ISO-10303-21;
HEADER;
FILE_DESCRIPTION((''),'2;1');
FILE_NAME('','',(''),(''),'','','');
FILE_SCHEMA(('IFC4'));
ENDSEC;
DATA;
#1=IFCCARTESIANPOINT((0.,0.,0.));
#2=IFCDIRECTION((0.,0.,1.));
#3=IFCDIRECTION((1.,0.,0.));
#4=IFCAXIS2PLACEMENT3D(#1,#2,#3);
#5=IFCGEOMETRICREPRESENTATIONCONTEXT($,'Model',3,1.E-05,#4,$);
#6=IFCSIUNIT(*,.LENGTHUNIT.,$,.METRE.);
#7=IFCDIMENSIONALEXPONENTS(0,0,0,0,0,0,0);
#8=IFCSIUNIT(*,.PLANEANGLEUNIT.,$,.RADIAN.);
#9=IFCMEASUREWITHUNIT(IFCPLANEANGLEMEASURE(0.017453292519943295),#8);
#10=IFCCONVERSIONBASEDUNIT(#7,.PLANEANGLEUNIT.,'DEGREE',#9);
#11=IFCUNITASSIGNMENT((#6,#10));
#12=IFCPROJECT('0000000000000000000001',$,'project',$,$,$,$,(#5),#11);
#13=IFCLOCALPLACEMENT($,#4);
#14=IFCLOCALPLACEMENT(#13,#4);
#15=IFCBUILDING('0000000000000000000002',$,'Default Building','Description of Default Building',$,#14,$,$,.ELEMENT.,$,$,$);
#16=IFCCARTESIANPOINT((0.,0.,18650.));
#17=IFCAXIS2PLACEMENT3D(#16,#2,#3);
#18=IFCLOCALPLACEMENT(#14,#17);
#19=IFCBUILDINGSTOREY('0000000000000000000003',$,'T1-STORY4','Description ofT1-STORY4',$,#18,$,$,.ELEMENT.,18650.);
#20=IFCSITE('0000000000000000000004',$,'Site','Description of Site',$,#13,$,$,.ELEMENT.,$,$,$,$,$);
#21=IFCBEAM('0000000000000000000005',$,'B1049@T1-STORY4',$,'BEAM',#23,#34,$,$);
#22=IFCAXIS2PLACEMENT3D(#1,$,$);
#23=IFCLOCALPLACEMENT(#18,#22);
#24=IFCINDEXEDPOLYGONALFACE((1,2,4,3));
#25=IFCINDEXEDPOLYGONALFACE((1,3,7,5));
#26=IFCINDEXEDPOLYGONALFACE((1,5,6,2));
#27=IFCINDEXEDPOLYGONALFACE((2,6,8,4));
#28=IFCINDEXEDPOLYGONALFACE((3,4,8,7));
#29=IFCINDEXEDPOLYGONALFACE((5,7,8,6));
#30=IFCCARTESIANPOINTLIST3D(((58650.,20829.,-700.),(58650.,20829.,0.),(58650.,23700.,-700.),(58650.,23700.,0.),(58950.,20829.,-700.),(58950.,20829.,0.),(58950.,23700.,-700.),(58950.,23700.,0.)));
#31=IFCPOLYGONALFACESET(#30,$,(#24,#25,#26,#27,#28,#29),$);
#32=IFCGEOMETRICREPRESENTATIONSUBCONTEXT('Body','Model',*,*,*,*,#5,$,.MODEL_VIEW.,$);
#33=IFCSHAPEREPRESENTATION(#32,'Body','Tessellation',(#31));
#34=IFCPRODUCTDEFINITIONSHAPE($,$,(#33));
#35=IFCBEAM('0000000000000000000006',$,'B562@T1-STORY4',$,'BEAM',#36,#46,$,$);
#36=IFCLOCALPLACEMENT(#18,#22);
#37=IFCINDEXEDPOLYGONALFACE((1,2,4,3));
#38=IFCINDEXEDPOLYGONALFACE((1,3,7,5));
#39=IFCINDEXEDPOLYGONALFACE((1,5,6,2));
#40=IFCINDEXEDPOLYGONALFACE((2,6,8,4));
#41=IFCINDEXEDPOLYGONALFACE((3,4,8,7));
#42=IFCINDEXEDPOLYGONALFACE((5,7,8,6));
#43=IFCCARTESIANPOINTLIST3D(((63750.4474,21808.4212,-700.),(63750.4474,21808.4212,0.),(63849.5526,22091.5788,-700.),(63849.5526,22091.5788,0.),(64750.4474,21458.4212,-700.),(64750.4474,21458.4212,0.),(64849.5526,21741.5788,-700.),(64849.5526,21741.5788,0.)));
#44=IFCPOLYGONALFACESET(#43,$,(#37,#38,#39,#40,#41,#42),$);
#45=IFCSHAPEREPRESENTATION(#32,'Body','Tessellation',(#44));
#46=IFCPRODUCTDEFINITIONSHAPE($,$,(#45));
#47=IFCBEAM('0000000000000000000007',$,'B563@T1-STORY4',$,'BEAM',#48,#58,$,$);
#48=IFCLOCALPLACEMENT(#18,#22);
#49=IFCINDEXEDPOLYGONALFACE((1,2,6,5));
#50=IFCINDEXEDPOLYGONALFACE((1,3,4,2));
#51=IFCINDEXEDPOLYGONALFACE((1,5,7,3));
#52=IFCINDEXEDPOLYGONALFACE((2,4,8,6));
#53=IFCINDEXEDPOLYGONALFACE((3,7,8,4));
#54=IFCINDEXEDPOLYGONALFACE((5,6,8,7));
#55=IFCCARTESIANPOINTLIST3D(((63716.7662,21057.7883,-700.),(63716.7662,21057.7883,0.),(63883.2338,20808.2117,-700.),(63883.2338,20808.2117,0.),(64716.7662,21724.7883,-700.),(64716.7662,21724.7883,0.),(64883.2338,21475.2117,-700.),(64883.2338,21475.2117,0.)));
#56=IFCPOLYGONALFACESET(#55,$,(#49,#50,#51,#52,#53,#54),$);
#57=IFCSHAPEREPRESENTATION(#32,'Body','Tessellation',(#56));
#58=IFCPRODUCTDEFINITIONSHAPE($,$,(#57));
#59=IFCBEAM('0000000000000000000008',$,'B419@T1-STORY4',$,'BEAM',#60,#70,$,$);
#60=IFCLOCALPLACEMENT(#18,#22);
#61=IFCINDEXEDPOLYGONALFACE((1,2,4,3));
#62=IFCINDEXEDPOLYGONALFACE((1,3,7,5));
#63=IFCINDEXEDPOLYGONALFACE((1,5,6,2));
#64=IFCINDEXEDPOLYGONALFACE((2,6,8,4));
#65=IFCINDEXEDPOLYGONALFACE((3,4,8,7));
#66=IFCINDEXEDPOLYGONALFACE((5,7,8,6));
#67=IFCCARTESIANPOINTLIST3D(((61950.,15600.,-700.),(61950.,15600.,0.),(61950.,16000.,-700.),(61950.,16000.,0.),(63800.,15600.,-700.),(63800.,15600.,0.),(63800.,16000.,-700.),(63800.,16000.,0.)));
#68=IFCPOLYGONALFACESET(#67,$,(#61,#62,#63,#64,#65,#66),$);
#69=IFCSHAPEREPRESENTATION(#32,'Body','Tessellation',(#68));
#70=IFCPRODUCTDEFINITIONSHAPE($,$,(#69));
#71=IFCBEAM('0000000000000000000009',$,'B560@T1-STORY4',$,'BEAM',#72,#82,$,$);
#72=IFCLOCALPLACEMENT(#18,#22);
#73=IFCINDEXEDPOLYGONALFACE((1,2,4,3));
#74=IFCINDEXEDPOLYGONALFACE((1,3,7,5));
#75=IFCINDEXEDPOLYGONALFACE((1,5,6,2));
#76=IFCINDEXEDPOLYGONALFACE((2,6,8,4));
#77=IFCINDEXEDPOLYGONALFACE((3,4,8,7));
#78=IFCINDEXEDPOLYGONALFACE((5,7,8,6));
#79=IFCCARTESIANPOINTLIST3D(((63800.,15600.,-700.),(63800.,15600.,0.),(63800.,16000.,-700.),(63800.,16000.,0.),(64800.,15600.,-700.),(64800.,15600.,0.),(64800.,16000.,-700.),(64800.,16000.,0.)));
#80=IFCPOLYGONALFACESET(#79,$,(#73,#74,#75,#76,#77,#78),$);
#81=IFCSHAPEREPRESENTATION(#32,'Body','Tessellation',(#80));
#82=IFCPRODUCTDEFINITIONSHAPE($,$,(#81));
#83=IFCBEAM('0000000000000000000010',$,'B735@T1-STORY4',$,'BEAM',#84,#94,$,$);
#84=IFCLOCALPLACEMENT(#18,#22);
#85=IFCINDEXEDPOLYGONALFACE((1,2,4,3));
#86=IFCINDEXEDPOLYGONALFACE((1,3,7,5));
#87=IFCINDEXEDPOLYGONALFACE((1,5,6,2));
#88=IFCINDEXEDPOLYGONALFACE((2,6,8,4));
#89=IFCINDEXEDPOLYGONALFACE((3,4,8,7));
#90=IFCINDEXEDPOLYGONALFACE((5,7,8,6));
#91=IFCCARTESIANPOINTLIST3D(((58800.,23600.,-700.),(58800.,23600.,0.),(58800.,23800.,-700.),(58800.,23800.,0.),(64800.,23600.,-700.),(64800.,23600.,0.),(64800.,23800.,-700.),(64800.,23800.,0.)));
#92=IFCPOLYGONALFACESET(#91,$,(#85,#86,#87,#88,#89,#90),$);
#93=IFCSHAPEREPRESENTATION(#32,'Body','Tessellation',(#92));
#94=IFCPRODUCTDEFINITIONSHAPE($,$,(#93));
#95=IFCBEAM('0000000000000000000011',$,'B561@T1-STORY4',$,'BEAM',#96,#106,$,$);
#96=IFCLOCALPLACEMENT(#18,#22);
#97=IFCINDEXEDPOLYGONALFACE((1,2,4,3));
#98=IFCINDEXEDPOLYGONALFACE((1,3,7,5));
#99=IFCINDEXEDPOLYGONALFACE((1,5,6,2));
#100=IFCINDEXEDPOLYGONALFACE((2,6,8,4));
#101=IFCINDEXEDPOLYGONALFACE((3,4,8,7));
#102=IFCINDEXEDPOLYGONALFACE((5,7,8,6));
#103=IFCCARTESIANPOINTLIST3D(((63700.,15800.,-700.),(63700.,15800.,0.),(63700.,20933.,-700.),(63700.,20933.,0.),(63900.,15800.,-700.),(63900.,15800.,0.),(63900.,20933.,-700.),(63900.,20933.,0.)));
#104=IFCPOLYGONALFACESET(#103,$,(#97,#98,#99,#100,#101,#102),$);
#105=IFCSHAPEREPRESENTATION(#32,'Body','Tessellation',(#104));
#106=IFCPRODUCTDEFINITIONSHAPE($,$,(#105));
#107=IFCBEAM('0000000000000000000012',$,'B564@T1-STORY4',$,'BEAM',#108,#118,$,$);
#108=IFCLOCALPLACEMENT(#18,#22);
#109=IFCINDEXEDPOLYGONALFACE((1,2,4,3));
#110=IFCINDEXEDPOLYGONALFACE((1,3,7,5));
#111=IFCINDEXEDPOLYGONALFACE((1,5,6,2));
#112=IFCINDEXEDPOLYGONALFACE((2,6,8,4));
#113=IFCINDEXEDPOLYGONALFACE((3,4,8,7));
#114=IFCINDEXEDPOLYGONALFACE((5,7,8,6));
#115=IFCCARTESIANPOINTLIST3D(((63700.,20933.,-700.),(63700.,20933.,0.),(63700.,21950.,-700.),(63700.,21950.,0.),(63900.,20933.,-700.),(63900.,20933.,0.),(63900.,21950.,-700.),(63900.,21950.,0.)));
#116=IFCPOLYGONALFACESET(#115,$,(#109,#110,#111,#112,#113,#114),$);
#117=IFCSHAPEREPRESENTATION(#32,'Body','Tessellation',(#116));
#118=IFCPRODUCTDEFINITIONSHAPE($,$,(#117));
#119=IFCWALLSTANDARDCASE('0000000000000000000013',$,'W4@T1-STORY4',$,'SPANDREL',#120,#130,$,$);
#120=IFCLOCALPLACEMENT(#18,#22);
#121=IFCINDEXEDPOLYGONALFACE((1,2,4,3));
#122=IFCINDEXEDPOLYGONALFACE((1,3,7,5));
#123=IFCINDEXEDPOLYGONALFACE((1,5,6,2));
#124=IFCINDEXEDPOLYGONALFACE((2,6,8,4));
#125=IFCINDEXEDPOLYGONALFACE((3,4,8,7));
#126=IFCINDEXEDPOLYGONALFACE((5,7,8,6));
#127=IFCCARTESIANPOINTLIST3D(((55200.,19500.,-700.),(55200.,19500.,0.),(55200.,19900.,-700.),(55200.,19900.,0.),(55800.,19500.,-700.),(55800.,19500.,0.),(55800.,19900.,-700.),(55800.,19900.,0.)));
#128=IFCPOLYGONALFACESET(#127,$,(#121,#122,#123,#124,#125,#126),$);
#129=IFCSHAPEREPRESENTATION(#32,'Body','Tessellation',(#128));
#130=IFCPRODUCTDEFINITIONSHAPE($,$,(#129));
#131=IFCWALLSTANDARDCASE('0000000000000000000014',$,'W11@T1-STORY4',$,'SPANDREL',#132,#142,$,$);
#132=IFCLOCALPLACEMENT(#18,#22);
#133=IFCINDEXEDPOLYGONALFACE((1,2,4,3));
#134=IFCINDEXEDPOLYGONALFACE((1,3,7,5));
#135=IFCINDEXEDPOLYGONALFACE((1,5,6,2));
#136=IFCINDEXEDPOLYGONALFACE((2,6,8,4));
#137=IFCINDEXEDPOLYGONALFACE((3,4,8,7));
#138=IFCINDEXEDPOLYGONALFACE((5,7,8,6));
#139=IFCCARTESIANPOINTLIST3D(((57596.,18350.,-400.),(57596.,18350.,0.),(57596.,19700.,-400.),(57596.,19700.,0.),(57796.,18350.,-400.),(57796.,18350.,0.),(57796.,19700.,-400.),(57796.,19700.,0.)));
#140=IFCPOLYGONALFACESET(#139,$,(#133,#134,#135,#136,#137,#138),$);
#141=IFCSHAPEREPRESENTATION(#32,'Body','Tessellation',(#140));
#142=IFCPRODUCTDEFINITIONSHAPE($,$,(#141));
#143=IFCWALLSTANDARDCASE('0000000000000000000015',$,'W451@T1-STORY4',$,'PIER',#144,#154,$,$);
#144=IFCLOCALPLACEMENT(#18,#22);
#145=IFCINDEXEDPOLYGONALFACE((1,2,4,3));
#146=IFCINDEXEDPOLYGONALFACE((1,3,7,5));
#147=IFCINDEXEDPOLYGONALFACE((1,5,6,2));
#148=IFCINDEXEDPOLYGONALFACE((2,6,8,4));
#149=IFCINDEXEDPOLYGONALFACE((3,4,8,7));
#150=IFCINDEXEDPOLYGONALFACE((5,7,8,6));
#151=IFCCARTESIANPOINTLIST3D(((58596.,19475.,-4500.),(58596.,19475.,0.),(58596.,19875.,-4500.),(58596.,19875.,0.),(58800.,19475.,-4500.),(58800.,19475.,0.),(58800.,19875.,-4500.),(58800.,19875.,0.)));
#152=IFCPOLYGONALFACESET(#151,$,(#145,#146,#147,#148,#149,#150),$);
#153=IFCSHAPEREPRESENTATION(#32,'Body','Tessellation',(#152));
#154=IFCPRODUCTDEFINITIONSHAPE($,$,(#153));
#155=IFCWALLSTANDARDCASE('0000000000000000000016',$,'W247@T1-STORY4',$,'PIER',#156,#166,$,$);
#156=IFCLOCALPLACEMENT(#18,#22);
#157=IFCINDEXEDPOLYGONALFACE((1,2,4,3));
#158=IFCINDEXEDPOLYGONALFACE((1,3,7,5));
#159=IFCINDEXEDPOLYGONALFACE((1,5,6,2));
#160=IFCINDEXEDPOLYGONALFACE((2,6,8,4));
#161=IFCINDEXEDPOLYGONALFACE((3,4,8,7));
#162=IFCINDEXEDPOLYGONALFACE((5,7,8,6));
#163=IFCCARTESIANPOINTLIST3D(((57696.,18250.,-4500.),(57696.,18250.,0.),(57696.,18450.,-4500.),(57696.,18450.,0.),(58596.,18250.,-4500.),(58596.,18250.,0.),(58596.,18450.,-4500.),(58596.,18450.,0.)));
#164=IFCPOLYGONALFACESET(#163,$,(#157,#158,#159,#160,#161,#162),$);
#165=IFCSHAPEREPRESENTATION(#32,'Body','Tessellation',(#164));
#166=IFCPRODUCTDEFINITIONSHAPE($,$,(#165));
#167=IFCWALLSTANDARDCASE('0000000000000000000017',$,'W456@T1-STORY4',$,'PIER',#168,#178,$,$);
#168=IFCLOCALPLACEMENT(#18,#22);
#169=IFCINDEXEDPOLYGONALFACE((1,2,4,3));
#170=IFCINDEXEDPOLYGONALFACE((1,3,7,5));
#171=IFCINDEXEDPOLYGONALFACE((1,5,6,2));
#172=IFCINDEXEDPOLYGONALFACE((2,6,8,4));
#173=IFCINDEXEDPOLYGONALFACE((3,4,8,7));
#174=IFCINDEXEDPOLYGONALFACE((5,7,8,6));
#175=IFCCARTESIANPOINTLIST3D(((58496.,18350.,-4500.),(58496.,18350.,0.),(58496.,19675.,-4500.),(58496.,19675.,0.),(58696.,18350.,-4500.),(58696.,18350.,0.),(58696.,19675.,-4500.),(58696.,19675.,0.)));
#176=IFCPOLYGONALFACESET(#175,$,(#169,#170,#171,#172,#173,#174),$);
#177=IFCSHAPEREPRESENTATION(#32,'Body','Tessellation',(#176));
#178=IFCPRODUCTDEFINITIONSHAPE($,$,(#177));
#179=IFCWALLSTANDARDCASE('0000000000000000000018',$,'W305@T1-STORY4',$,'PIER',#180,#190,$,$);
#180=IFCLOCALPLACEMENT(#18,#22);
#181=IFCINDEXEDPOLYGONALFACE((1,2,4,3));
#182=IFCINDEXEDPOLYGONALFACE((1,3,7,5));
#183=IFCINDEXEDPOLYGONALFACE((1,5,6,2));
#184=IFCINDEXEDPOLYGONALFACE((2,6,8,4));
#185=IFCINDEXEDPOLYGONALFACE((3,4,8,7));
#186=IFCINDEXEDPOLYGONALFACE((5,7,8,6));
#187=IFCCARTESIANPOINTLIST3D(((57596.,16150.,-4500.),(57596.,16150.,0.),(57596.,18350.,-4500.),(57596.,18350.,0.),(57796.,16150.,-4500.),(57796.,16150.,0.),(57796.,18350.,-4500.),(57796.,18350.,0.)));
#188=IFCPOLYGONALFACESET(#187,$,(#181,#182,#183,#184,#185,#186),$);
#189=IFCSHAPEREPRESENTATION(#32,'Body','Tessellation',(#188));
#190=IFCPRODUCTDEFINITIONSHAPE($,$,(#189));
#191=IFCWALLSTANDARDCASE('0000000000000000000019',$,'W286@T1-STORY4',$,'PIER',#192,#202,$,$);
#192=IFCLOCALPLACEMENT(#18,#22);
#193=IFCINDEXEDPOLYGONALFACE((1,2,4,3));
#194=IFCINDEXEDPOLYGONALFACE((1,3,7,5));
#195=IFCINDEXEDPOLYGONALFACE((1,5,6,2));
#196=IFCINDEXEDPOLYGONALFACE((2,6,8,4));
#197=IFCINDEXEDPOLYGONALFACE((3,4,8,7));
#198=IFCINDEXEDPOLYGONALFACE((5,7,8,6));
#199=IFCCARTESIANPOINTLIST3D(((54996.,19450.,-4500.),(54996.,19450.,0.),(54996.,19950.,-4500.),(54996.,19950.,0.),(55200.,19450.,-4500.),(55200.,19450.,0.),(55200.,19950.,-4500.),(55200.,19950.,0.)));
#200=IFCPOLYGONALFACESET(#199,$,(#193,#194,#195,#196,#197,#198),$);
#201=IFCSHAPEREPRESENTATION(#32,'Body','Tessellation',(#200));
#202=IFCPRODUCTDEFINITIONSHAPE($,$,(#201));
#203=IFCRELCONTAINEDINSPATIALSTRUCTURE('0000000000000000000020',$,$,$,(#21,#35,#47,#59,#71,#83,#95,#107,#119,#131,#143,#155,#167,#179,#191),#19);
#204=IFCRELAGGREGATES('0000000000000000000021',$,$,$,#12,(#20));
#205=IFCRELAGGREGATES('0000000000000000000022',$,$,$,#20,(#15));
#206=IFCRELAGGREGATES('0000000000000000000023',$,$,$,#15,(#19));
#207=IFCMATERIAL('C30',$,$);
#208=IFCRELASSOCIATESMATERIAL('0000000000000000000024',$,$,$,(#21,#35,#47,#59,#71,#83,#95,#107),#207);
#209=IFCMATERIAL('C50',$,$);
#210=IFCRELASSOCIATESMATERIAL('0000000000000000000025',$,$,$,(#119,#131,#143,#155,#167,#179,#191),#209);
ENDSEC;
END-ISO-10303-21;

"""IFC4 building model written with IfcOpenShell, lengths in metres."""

from ifc_helpers import new_model, entity, si_unit, converted_unit, frame, origin_with_axes, place, context, subcontext, project, spatial, indexed_curve, rectangle, outline, extrude, material, element, save


model = new_model("IFC4")

# Units and contexts
model_context = context("Model", 3, precision=1e-05, world=origin_with_axes())
body_context = subcontext(model_context, "Body", "Model", "MODEL_VIEW")
ifc_project = project(units=[si_unit("LENGTHUNIT", "METRE"), converted_unit("PLANEANGLEUNIT", "DEGREE", entity("IfcPlaneAngleMeasure", 0.017453292519943295), si_unit("PLANEANGLEUNIT", "RADIAN"), dimensions=[0, 0, 0, 0, 0, 0, 0])], contexts=[model_context])

# Site, building, storey
site_placement = place(None, origin_with_axes())
site = spatial("IfcSite", under=ifc_project, at=site_placement, Name="Site", Description="Description of Site", CompositionType="ELEMENT")
building_placement = place(site_placement, origin_with_axes())
building = spatial("IfcBuilding", under=site, at=building_placement, Name="Default Building", Description="Description of Default Building", CompositionType="ELEMENT")
storey_placement = place(building_placement, frame((0.0, 0.0, 18650.0), z_axis=(0.0, 0.0, 1.0), x_axis=(1.0, 0.0, 0.0)))
storey = spatial("IfcBuildingStorey", under=building, at=storey_placement, Name="T1-STORY4", Description="Description ofT1-STORY4", CompositionType="ELEMENT", Elevation=18650.0)

# Beams
ifc_material_1 = material(Name="C30")
beam_1_placement = place(storey_placement, frame((58800.0, 20829.0, -350.0), z_axis=(0.0, 1.0, 0.0), x_axis=(-1.0, 0.0, 0.0)))
element("IfcBeam", 1, at=beam_1_placement, inside=storey, material=ifc_material_1, Name="B1049@T1-STORY4", ObjectType="BEAM", context=body_context, shape_type="SweptSolid", body=[
    extrude(rectangle(XDim=300.0, YDim=700.0), origin_with_axes(), (0.0, 0.0, 1.0), 2871.0),
])
beam_2_placement = place(storey_placement, frame((63800.0, 21950.0, -350.0), z_axis=(0.943858, -0.33035, 0.0), x_axis=(0.33035, 0.943858, 0.0)))
element("IfcBeam", 2, at=beam_2_placement, inside=storey, material=ifc_material_1, Name="B562@T1-STORY4", ObjectType="BEAM", context=body_context, shape_type="SweptSolid", body=[
    extrude(rectangle(XDim=300.0, YDim=700.0), origin_with_axes(), (0.0, 0.0, 1.0), 1059.481),
])
beam_3_placement = place(storey_placement, frame((63800.0, 20933.0, -350.0), z_axis=(0.831922, 0.554892, 0.0), x_axis=(-0.554892, 0.831922, 0.0)))
element("IfcBeam", 3, at=beam_3_placement, inside=storey, material=ifc_material_1, Name="B563@T1-STORY4", ObjectType="BEAM", context=body_context, shape_type="SweptSolid", body=[
    extrude(rectangle(XDim=300.0, YDim=700.0), origin_with_axes(), (0.0, 0.0, 1.0), 1202.0354),
])
beam_4_placement = place(storey_placement, frame((61950.0, 15800.0, -350.0), z_axis=(1.0, 0.0, 0.0), x_axis=(0.0, 1.0, 0.0)))
element("IfcBeam", 4, at=beam_4_placement, inside=storey, material=ifc_material_1, Name="B419@T1-STORY4", ObjectType="BEAM", context=body_context, shape_type="SweptSolid", body=[
    extrude(rectangle(XDim=400.0, YDim=700.0), origin_with_axes(), (0.0, 0.0, 1.0), 1850.0),
])
beam_5_placement = place(storey_placement, frame((63800.0, 15800.0, -350.0), z_axis=(1.0, 0.0, 0.0), x_axis=(0.0, 1.0, 0.0)))
element("IfcBeam", 5, at=beam_5_placement, inside=storey, material=ifc_material_1, Name="B560@T1-STORY4", ObjectType="BEAM", context=body_context, shape_type="SweptSolid", body=[
    extrude(rectangle(XDim=400.0, YDim=700.0), origin_with_axes(), (0.0, 0.0, 1.0), 1000.0),
])
beam_6_placement = place(storey_placement, frame((58800.0, 23700.0, -350.0), z_axis=(1.0, 0.0, 0.0), x_axis=(0.0, 1.0, 0.0)))
element("IfcBeam", 6, at=beam_6_placement, inside=storey, material=ifc_material_1, Name="B735@T1-STORY4", ObjectType="BEAM", context=body_context, shape_type="SweptSolid", body=[
    extrude(rectangle(XDim=200.0, YDim=700.0), origin_with_axes(), (0.0, 0.0, 1.0), 6000.0),
])
beam_7_placement = place(storey_placement, frame((63800.0, 15800.0, -350.0), z_axis=(0.0, 1.0, 0.0), x_axis=(-1.0, 0.0, 0.0)))
element("IfcBeam", 7, at=beam_7_placement, inside=storey, material=ifc_material_1, Name="B561@T1-STORY4", ObjectType="BEAM", context=body_context, shape_type="SweptSolid", body=[
    extrude(rectangle(XDim=200.0, YDim=700.0), origin_with_axes(), (0.0, 0.0, 1.0), 5133.0),
])
beam_8_placement = place(storey_placement, frame((63800.0, 20933.0, -350.0), z_axis=(0.0, 1.0, 0.0), x_axis=(-1.0, 0.0, 0.0)))
element("IfcBeam", 8, at=beam_8_placement, inside=storey, material=ifc_material_1, Name="B564@T1-STORY4", ObjectType="BEAM", context=body_context, shape_type="SweptSolid", body=[
    extrude(rectangle(XDim=200.0, YDim=700.0), origin_with_axes(), (0.0, 0.0, 1.0), 1017.0),
])
ifc_material_2 = material(Name="C50")

# Walls
wall_1_placement = place(storey_placement, frame((55200.0, 19700.0, -700.0), z_axis=(0.0, 0.0, 1.0), x_axis=(1.0, 0.0, 0.0)))
element("IfcWallStandardCase", 9, at=wall_1_placement, inside=storey, material=ifc_material_2, Name="W4@T1-STORY4", ObjectType="SPANDREL", context=body_context, shape_type="SweptSolid", body=[
    extrude(outline(indexed_curve([(0.0, -200.0), (0.0, 200.0), (600.0, 200.0), (600.0, -200.0), (0.0, -200.0)], self_intersect=False)), origin_with_axes(), (0.0, 0.0, 1.0), 700.0),
])
wall_2_placement = place(storey_placement, frame((57696.0, 18350.0, -400.0), z_axis=(0.0, 0.0, 1.0), x_axis=(0.0, 1.0, 0.0)))
element("IfcWallStandardCase", 10, at=wall_2_placement, inside=storey, material=ifc_material_2, Name="W11@T1-STORY4", ObjectType="SPANDREL", context=body_context, shape_type="SweptSolid", body=[
    extrude(outline(indexed_curve([(0.0, -100.0), (0.0, 100.0), (1350.0, 100.0), (1350.0, -100.0), (0.0, -100.0)], self_intersect=False)), origin_with_axes(), (0.0, 0.0, 1.0), 400.0),
])
wall_3_placement = place(storey_placement, frame((58596.0, 19675.0, -4500.0), z_axis=(0.0, 0.0, 1.0), x_axis=(1.0, 0.0, 0.0)))
element("IfcWallStandardCase", 11, at=wall_3_placement, inside=storey, material=ifc_material_2, Name="W451@T1-STORY4", ObjectType="PIER", context=body_context, shape_type="SweptSolid", body=[
    extrude(outline(indexed_curve([(0.0, -200.0), (0.0, 200.0), (204.0, 200.0), (204.0, -200.0), (0.0, -200.0)], self_intersect=False)), origin_with_axes(), (0.0, 0.0, 1.0), 4500.0),
])
wall_4_placement = place(storey_placement, frame((57696.0, 18350.0, -4500.0), z_axis=(0.0, 0.0, 1.0), x_axis=(1.0, 0.0, 0.0)))
element("IfcWallStandardCase", 12, at=wall_4_placement, inside=storey, material=ifc_material_2, Name="W247@T1-STORY4", ObjectType="PIER", context=body_context, shape_type="SweptSolid", body=[
    extrude(outline(indexed_curve([(0.0, -100.0), (0.0, 100.0), (900.0, 100.0), (900.0, -100.0), (0.0, -100.0)], self_intersect=False)), origin_with_axes(), (0.0, 0.0, 1.0), 4500.0),
])
wall_5_placement = place(storey_placement, frame((58596.0, 18350.0, -4500.0), z_axis=(0.0, 0.0, 1.0), x_axis=(0.0, 1.0, 0.0)))
element("IfcWallStandardCase", 13, at=wall_5_placement, inside=storey, material=ifc_material_2, Name="W456@T1-STORY4", ObjectType="PIER", context=body_context, shape_type="SweptSolid", body=[
    extrude(outline(indexed_curve([(0.0, -100.0), (0.0, 100.0), (1325.0, 100.0), (1325.0, -100.0), (0.0, -100.0)], self_intersect=False)), origin_with_axes(), (0.0, 0.0, 1.0), 4500.0),
])
wall_6_placement = place(storey_placement, frame((57696.0, 16150.0, -4500.0), z_axis=(0.0, 0.0, 1.0), x_axis=(0.0, 1.0, 0.0)))
element("IfcWallStandardCase", 14, at=wall_6_placement, inside=storey, material=ifc_material_2, Name="W305@T1-STORY4", ObjectType="PIER", context=body_context, shape_type="SweptSolid", body=[
    extrude(outline(indexed_curve([(0.0, -100.0), (0.0, 100.0), (2200.0, 100.0), (2200.0, -100.0), (0.0, -100.0)], self_intersect=False)), origin_with_axes(), (0.0, 0.0, 1.0), 4500.0),
])
wall_7_placement = place(storey_placement, frame((54996.0, 19700.0, -4500.0), z_axis=(0.0, 0.0, 1.0), x_axis=(1.0, 0.0, 0.0)))
element("IfcWallStandardCase", 15, at=wall_7_placement, inside=storey, material=ifc_material_2, Name="W286@T1-STORY4", ObjectType="PIER", context=body_context, shape_type="SweptSolid", body=[
    extrude(outline(indexed_curve([(0.0, -250.0), (0.0, 250.0), (204.0, 250.0), (204.0, -250.0), (0.0, -250.0)], self_intersect=False)), origin_with_axes(), (0.0, 0.0, 1.0), 4500.0),
])

save(model, "model.ifc")
